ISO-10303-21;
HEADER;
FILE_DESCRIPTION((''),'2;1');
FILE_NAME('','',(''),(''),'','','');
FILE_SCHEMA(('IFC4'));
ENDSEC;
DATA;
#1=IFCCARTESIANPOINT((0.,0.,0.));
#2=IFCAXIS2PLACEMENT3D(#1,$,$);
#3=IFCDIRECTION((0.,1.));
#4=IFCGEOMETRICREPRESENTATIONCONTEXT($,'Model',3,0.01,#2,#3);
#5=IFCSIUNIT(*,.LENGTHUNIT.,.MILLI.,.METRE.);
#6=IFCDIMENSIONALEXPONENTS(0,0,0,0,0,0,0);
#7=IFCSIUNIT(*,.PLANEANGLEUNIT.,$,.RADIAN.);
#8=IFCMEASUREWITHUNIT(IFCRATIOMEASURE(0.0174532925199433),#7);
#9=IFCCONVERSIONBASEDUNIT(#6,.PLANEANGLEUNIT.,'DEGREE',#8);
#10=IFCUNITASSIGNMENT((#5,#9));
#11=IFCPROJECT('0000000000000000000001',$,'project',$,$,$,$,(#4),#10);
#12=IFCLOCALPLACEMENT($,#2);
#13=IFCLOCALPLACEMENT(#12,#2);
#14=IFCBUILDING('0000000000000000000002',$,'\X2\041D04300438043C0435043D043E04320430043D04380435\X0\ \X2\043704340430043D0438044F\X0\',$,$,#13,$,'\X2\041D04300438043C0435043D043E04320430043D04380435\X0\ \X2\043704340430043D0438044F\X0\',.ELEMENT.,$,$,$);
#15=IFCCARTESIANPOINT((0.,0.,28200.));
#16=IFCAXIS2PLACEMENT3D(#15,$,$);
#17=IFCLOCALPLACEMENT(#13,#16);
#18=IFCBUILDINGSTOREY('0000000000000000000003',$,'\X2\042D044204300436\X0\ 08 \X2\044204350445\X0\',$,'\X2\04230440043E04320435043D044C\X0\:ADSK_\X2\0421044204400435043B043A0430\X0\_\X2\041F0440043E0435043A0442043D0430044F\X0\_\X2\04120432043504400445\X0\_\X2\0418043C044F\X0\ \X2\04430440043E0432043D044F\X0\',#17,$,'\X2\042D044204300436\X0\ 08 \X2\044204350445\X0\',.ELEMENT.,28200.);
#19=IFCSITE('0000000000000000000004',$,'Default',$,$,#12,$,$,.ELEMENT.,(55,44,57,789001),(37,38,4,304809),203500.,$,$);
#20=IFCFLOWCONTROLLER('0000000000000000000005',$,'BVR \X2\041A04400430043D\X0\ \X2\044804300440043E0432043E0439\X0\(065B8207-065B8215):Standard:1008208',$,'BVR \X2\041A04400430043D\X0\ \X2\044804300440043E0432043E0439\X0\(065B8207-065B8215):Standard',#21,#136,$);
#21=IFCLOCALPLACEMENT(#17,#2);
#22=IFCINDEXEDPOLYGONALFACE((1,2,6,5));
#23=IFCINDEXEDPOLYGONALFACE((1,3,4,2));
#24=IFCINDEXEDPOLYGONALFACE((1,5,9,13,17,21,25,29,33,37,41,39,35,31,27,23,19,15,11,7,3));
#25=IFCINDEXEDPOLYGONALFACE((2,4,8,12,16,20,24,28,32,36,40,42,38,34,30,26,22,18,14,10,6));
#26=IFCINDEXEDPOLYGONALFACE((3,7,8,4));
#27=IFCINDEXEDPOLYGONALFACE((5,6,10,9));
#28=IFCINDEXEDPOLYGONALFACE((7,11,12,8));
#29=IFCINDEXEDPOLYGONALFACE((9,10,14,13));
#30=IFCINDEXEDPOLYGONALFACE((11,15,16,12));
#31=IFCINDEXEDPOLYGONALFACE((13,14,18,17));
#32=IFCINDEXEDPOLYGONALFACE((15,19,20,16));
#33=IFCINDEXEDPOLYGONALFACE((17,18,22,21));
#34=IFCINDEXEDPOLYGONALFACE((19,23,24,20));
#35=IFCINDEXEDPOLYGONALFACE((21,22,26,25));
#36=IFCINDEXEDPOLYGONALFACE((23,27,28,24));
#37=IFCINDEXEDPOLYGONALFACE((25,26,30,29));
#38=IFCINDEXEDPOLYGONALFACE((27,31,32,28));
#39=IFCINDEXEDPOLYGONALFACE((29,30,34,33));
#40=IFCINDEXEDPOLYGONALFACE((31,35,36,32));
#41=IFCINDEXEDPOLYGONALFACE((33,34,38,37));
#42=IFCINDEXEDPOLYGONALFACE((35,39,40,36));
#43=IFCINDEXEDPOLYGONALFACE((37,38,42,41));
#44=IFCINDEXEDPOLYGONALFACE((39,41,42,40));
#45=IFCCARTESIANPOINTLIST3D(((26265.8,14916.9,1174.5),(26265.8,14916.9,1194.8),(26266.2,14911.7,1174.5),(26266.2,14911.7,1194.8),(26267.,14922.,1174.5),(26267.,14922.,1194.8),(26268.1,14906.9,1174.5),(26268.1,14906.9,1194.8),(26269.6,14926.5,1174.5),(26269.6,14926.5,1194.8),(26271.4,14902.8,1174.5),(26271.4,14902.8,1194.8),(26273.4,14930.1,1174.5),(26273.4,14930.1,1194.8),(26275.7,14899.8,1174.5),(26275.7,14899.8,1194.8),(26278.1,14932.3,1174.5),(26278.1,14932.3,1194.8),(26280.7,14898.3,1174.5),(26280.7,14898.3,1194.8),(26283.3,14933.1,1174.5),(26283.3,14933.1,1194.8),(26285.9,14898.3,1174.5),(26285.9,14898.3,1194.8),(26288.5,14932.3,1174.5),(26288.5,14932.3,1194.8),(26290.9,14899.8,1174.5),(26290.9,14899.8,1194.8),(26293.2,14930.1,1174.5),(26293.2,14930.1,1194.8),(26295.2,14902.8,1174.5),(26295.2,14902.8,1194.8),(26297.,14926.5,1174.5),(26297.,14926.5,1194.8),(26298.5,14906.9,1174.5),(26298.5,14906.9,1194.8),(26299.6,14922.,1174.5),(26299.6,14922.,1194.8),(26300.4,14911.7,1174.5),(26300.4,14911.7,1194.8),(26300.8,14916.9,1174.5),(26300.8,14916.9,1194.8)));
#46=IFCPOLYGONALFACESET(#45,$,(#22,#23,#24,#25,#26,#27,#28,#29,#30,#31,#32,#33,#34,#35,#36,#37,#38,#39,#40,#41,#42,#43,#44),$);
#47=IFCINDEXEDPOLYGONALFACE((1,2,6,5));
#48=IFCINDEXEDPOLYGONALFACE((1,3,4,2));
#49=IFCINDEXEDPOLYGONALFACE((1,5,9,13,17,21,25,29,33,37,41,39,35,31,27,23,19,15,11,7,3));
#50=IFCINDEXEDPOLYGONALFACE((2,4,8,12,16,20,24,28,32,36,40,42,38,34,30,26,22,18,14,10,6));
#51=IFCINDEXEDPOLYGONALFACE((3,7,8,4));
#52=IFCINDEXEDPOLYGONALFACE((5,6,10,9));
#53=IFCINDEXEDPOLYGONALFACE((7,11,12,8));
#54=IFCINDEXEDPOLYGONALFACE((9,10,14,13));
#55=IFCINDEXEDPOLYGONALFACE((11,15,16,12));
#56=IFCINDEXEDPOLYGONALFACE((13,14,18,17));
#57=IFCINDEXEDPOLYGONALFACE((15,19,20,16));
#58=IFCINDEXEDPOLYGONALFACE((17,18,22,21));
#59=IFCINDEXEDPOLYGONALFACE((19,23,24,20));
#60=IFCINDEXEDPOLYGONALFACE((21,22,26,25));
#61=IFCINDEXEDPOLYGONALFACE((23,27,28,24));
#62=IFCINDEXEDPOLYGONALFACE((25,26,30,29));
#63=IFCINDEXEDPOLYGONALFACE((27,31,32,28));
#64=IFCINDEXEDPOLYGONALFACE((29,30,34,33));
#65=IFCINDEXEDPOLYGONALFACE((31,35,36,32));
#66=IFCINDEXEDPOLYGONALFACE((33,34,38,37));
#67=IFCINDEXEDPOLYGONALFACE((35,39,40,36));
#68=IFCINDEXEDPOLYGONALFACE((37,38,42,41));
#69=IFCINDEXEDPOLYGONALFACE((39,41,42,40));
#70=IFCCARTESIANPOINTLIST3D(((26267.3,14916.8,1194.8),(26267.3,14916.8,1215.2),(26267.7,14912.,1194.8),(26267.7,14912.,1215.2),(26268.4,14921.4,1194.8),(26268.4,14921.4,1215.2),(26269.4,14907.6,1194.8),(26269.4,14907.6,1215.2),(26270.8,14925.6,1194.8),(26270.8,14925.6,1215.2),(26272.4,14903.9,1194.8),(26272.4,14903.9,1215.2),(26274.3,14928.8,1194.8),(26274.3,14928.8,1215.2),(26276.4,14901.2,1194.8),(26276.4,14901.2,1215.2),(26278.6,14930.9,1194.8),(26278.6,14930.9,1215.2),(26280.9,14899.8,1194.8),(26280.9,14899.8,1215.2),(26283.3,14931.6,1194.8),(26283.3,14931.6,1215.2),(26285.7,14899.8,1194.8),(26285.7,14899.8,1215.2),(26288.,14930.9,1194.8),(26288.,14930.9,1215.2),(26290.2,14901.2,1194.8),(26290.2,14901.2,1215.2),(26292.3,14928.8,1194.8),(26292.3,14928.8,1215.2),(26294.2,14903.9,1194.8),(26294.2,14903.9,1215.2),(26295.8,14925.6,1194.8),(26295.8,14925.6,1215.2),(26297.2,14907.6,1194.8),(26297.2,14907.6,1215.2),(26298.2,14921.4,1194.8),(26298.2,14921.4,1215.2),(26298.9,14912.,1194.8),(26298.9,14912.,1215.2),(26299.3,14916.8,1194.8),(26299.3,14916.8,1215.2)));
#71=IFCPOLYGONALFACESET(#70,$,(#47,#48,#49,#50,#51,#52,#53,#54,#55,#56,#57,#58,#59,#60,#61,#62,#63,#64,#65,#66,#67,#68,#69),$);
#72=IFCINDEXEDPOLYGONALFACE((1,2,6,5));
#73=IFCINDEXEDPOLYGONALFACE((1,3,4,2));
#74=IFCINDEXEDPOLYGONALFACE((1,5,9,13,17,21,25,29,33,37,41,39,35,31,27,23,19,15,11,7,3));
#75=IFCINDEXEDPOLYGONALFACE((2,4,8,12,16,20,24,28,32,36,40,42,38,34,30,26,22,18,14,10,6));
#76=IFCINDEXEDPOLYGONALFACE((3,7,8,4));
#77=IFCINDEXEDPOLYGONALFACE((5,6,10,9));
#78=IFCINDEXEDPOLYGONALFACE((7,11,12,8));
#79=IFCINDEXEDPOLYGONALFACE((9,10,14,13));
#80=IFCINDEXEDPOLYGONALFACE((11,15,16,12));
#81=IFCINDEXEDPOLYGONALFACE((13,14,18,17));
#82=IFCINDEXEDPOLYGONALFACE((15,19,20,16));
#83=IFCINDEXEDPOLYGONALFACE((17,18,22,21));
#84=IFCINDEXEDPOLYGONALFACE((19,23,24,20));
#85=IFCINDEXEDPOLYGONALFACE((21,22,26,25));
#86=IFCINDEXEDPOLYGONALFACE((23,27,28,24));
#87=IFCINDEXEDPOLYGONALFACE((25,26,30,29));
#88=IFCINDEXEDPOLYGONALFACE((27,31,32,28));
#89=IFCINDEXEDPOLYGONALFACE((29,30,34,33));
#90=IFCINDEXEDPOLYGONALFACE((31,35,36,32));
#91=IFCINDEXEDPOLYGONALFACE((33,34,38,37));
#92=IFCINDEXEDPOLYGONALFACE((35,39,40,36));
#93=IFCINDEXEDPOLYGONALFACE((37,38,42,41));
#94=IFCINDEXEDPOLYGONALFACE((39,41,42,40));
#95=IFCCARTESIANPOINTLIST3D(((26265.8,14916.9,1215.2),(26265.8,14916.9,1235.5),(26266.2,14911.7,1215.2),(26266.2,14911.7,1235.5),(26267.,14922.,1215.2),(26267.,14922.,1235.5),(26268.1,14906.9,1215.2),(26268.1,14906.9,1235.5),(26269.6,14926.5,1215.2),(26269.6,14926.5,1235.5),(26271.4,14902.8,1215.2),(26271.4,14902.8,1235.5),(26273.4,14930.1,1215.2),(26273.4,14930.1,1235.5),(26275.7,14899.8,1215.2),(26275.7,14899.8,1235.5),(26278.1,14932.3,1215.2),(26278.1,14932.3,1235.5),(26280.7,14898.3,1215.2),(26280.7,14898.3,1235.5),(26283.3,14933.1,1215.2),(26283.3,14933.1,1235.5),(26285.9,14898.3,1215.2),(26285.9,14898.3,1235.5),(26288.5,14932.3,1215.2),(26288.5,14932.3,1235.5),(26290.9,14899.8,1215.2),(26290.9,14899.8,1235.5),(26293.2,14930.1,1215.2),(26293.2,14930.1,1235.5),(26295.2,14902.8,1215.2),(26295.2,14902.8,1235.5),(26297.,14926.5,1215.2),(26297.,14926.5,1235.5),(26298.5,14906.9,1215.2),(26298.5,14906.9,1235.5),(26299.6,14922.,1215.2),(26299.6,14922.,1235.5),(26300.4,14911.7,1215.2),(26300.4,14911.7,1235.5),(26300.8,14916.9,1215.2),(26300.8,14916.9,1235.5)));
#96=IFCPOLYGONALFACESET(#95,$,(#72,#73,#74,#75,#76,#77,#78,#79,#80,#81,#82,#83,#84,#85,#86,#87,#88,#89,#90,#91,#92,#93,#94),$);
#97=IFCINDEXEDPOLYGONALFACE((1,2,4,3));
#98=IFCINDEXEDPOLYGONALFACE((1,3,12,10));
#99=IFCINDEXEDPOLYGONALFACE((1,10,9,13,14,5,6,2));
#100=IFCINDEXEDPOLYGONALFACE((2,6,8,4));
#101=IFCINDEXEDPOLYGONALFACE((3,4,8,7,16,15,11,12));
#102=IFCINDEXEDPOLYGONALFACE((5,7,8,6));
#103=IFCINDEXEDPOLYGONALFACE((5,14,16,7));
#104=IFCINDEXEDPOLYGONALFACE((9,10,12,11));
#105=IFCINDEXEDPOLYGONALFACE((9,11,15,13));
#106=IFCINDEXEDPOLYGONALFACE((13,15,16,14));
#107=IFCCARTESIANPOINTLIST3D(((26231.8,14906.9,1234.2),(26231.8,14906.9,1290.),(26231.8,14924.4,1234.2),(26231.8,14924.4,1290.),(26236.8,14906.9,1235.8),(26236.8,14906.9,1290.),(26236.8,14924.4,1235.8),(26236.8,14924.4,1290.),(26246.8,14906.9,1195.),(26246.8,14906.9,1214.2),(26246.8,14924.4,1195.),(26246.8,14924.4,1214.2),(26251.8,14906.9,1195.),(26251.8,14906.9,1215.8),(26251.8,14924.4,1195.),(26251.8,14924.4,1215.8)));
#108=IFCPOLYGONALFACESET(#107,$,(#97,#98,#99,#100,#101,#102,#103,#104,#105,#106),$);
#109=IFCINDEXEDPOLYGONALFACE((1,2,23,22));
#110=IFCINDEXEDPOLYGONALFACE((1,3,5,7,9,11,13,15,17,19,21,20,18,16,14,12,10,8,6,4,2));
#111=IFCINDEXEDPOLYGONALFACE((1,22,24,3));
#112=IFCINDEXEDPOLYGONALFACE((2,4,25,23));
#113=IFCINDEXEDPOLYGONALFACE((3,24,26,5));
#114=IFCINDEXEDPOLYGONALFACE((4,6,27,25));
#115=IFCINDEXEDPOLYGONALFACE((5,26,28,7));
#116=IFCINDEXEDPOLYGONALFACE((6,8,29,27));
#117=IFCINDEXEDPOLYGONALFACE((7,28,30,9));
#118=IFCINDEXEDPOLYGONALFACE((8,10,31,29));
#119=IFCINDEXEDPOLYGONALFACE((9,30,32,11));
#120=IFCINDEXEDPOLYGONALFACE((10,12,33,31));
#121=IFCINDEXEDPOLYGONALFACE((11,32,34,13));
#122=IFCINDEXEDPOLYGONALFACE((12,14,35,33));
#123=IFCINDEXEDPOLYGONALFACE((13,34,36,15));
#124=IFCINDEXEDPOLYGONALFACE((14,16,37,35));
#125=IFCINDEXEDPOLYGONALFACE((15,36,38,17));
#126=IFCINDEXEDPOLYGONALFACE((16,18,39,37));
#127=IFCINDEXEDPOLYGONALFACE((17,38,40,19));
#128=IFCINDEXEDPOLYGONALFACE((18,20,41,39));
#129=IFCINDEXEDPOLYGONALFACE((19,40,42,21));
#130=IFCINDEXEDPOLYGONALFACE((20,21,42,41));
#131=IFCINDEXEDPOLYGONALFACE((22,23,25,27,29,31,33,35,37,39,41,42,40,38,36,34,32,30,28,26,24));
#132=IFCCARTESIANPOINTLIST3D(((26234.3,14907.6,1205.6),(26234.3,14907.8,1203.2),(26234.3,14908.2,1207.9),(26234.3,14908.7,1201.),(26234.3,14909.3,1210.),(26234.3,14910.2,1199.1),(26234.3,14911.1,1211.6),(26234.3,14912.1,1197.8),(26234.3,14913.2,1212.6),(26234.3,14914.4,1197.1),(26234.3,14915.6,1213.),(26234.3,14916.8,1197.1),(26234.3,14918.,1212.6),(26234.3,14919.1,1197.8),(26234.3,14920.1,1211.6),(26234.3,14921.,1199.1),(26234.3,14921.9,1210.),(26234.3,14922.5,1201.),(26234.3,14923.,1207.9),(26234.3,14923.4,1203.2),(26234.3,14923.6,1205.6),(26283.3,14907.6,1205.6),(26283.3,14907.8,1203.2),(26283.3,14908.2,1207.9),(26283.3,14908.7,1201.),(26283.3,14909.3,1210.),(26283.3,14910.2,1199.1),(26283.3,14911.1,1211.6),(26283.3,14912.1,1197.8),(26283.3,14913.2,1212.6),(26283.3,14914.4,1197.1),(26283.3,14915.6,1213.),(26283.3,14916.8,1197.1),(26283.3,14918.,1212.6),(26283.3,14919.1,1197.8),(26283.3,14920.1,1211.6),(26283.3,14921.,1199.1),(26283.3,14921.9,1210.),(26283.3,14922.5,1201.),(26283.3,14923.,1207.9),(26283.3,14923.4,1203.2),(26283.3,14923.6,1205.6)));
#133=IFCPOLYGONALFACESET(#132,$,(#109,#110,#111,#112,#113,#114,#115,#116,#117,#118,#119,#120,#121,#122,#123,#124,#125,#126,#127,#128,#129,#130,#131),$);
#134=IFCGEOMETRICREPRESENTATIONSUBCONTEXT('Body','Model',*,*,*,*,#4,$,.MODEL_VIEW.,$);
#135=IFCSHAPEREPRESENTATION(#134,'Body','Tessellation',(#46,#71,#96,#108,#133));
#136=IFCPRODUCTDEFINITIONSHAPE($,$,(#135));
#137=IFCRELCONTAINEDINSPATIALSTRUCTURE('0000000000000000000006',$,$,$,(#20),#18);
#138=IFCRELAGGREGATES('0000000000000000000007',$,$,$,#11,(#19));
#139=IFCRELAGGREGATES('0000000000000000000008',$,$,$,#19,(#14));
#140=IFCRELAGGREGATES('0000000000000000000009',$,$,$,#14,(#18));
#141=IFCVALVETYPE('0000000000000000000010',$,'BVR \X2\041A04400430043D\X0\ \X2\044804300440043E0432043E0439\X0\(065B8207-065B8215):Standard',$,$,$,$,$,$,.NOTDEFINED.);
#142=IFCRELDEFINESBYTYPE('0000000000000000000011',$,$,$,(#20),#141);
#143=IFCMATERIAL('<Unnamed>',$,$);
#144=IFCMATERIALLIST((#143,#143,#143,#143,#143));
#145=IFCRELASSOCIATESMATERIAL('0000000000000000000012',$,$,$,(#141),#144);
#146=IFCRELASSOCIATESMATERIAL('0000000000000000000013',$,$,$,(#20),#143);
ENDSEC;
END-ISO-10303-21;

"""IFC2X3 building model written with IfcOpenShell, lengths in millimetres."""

from ifc_helpers import new_model, entity, si_unit, converted_unit, direction, frame, origin, origin_2d_with_axis, place, context, subcontext, project, spatial, polyline, circle, outline, extrude, source, transform, mapped, material, material_list, type_object, type_shapes, element, save


model = new_model("IFC2X3")

# Units and contexts
model_context = context("Model", 3, precision=0.01, world=origin(), true_north=direction((0.0, 1.0)))
body_context = subcontext(model_context, "Body", "Model", "MODEL_VIEW")
ifc_project = project(units=[si_unit("LENGTHUNIT", "METRE", prefix="MILLI"), converted_unit("PLANEANGLEUNIT", "DEGREE", entity("IfcRatioMeasure", 0.0174532925199433), si_unit("PLANEANGLEUNIT", "RADIAN"), dimensions=[0, 0, 0, 0, 0, 0, 0])], contexts=[model_context])

# Site, building, storey
site_placement = place(None, origin())
site = spatial("IfcSite", under=ifc_project, at=site_placement, Name="Default", CompositionType="ELEMENT", RefLatitude=(55, 44, 57, 789001), RefLongitude=(37, 38, 4, 304809), RefElevation=203500.0)
building_placement = place(site_placement, origin())
building = spatial("IfcBuilding", under=site, at=building_placement, Name="Наименование здания", LongName="Наименование здания", CompositionType="ELEMENT")
storey_placement = place(building_placement, frame((0.0, 0.0, 28200.0)))
storey = spatial("IfcBuildingStorey", under=building, at=storey_placement, Name="Этаж 08 тех", ObjectType="Уровень:ADSK_Стрелка_Проектная_Вверх_Имя уровня", LongName="Этаж 08 тех", CompositionType="ELEMENT", Elevation=28200.0)

# Flow controller
ifc_material = material(Name="<Unnamed>")
ifc_material_list_1 = material_list([ifc_material, ifc_material, ifc_material, ifc_material, ifc_material])
valve_type_1 = type_object("IfcValveType", Name="BVR Кран шаровой(065B8207-065B8215):Standard", PredefinedType="NOTDEFINED", material=ifc_material_list_1)
shared_shape_1 = source(origin(), body_context, "Body", "SweptSolid", [
    extrude(circle(Radius=17.5, at=origin_2d_with_axis()), frame((-30.5, 0.0, 0.0), z_axis=(1.0, 0.0, 0.0), x_axis=(0.0, 1.0, 0.0)), (0.0, 0.0, 1.0), 20.3),
    extrude(circle(Radius=16.0, at=origin_2d_with_axis()), frame((-10.2, 0.0, 0.0), z_axis=(1.0, 0.0, 0.0), x_axis=(0.0, 1.0, 0.0)), (0.0, 0.0, 1.0), 20.3),
    extrude(circle(Radius=17.5, at=origin_2d_with_axis()), frame((10.2, 0.0, 0.0), z_axis=(1.0, 0.0, 0.0), x_axis=(0.0, 1.0, 0.0)), (0.0, 0.0, 1.0), 20.3),
    extrude(outline(polyline([(-38.8, -5.0), (-38.8, -10.0), (-17.9, -10.0), (2.1, 5.0), (56.2, 5.0), (56.2, 10.0), (0.4, 10.0), (-19.6, -5.0), (-38.8, -5.0)])), frame((28.8, -8.8, 41.5), z_axis=(0.0, -1.0, 0.0), x_axis=(1.0, 0.0, 0.0)), (0.0, 0.0, -1.0), 17.5),
    extrude(circle(Radius=8.0, at=origin_2d_with_axis()), origin(), (0.0, 0.0, 1.0), 49.0),
])
type_shapes(valve_type_1, [shared_shape_1])
for number, where, z_axis, x_axis, name in (
    (1, (26283.3, 14915.6, 1205.0), (-1.0, 0.0, 0.0), (0.0, 0.0, 1.0), "BVR Кран шаровой(065B8207-065B8215):Standard:1008208"),
):
    element("IfcFlowController", number, at=place(storey_placement, frame(where, z_axis=z_axis, x_axis=x_axis)), inside=storey, type_object=valve_type_1, material=ifc_material, Name=name, ObjectType="BVR Кран шаровой(065B8207-065B8215):Standard", context=body_context, shape_type="MappedRepresentation", body=[
        mapped(shared_shape_1, transform((0.0, 0.0, 0.0), scale=1.0)),
    ])

save(model, "model.ifc")
